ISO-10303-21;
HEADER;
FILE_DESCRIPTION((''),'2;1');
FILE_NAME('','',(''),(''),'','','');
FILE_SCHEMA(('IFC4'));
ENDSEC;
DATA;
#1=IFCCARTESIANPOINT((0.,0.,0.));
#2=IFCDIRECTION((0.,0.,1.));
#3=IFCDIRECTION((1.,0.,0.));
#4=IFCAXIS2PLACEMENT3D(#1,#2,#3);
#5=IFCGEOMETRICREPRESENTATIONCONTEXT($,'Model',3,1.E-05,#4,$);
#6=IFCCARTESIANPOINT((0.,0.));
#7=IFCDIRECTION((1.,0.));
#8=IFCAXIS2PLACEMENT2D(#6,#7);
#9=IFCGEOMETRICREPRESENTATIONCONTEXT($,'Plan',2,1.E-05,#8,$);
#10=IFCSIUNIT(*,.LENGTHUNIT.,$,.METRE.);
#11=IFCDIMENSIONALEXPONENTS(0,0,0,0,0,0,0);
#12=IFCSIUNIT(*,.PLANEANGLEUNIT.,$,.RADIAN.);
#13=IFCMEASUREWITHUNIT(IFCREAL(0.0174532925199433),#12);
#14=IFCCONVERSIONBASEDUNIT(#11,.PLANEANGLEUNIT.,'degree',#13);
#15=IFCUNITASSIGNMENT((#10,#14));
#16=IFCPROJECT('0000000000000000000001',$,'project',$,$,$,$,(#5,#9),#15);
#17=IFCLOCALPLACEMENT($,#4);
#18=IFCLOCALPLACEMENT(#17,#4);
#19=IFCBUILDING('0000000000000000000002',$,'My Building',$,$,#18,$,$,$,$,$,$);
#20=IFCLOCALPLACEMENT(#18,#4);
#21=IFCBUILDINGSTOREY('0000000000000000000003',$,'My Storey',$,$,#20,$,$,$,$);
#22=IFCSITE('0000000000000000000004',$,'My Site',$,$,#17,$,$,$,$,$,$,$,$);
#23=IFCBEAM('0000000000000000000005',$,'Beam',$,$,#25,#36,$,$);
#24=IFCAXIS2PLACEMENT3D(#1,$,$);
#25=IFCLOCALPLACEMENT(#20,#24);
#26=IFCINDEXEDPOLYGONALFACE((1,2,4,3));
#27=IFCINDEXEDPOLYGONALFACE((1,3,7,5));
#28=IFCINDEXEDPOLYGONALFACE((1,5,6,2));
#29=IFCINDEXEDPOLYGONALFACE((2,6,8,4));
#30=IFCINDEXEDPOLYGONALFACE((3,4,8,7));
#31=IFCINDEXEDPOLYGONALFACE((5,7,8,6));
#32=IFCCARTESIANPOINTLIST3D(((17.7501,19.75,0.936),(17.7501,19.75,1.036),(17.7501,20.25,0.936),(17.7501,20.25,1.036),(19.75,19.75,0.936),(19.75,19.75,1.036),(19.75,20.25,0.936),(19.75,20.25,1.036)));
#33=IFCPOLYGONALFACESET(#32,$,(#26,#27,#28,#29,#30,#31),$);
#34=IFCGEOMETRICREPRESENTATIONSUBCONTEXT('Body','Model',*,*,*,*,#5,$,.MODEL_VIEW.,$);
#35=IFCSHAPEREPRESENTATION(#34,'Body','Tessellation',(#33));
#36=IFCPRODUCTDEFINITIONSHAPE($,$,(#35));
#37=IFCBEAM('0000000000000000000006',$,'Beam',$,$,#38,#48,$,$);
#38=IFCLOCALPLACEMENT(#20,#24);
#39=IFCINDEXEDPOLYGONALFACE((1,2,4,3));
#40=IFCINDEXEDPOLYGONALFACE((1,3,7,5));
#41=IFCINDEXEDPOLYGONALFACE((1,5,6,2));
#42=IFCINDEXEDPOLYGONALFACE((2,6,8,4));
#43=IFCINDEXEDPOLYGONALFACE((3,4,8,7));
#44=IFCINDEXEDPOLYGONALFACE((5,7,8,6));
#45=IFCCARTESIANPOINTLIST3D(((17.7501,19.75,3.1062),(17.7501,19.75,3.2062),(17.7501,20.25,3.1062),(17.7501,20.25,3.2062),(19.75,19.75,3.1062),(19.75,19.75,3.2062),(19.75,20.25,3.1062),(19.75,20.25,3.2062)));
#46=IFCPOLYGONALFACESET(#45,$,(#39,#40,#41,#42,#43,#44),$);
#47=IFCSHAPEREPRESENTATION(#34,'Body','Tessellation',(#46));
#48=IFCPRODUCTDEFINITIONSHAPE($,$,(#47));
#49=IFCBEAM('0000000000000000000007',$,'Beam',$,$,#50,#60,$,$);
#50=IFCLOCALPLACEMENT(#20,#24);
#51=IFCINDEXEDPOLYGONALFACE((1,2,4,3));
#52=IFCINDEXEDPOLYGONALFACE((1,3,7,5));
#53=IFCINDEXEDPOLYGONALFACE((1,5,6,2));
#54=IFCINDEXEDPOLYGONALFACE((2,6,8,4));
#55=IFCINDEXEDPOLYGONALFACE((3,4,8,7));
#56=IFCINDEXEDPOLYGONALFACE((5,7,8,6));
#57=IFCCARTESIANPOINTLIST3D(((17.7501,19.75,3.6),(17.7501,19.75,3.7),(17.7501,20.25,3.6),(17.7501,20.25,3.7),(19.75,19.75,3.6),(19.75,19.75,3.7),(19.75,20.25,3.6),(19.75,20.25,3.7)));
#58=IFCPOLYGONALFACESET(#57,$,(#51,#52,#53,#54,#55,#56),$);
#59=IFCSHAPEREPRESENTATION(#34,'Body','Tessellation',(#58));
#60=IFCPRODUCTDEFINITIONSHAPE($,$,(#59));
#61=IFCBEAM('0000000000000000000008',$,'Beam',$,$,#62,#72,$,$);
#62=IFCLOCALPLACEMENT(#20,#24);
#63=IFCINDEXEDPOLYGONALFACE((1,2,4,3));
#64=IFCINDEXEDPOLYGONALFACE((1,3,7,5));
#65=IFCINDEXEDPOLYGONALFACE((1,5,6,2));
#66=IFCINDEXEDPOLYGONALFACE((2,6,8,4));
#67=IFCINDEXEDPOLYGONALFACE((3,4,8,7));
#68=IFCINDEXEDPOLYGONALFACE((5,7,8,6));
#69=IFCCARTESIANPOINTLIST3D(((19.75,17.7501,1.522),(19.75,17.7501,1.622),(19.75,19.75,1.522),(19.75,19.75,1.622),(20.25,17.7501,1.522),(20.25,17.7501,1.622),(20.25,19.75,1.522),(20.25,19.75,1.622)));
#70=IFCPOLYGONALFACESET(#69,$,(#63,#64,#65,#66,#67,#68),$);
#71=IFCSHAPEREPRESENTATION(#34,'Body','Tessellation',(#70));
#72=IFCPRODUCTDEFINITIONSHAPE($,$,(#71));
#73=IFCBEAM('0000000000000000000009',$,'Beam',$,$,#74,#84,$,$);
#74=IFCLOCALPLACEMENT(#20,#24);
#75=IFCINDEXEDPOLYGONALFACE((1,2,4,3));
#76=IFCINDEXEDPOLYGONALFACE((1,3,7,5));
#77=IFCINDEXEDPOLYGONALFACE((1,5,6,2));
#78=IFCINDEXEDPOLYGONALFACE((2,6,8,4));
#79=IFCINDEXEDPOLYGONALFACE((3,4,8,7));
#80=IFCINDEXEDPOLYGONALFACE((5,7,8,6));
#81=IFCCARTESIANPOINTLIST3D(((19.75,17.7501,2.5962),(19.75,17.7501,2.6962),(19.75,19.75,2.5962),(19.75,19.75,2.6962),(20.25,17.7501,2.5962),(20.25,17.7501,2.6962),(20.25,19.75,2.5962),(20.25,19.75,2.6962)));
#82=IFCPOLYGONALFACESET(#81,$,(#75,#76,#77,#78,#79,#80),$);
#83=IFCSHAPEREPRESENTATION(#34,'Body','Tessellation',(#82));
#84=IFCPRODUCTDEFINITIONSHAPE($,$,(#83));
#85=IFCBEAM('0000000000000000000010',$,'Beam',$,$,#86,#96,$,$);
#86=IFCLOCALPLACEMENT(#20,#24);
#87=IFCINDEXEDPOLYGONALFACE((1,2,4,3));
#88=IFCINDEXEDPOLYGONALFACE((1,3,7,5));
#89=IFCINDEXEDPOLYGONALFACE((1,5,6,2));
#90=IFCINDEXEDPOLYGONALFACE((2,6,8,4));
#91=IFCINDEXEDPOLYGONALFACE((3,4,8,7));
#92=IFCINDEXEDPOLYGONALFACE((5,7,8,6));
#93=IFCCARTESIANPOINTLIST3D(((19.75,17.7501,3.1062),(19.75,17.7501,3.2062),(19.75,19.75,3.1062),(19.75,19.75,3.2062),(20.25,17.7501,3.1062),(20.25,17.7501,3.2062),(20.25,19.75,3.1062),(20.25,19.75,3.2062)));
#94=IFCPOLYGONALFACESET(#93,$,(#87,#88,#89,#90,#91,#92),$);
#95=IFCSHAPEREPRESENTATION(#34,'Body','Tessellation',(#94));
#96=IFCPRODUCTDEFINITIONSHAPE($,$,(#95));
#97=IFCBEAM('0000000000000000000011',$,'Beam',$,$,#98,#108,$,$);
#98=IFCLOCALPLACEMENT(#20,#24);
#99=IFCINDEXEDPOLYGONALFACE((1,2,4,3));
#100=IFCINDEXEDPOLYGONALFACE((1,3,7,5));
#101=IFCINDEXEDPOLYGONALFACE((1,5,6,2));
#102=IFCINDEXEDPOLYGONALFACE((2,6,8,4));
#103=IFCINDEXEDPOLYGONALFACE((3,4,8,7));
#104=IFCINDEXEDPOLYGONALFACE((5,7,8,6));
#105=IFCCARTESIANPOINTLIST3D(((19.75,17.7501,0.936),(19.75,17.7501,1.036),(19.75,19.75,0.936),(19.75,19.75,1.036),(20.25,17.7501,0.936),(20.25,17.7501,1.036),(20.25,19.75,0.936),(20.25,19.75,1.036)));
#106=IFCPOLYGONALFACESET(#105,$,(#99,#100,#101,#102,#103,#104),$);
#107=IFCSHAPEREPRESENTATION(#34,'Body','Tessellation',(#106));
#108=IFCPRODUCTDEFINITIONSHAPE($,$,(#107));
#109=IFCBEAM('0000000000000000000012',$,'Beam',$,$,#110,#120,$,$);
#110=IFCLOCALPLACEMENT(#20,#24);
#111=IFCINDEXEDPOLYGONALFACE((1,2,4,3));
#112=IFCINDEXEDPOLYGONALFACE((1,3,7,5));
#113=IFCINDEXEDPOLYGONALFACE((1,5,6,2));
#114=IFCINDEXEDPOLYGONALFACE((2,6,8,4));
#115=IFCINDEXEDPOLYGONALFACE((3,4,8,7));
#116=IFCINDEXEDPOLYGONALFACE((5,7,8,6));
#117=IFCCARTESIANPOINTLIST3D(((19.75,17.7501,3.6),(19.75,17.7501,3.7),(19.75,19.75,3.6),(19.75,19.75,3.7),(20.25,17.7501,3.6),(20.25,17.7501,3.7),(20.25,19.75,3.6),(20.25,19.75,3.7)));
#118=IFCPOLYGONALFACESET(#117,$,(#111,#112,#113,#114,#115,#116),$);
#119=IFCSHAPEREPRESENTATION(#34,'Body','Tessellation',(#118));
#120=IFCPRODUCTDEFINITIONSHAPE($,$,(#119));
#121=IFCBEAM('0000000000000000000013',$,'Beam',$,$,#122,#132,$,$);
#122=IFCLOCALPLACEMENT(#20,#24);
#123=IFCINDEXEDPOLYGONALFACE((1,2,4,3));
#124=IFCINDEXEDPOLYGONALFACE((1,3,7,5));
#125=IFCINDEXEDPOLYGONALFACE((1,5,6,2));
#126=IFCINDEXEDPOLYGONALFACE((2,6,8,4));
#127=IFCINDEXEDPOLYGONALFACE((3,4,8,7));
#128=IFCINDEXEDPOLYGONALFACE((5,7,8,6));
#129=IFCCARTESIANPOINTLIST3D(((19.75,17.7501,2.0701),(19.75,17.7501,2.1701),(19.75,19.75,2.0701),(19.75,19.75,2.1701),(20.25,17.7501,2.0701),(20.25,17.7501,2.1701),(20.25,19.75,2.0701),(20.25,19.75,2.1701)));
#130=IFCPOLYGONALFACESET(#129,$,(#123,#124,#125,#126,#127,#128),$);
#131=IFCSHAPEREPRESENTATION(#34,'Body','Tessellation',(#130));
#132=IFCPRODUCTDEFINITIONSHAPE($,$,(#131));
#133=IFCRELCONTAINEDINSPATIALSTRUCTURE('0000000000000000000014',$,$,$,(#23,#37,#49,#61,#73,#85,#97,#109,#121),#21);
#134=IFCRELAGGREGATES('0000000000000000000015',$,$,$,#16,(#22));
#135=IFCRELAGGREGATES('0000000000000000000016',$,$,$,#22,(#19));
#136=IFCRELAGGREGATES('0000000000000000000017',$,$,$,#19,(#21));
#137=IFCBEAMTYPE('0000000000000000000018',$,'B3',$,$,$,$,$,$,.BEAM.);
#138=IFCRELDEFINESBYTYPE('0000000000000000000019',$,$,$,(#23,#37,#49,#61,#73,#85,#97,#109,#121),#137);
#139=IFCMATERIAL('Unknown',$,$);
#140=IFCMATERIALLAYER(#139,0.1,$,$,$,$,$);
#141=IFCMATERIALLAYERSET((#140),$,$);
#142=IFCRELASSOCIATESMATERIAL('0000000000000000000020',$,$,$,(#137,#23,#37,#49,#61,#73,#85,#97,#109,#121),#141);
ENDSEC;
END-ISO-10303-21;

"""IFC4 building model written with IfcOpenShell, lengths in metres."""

from ifc_helpers import new_model, entity, si_unit, converted_unit, frame, origin_with_axes, origin_2d_with_axis, place, context, subcontext, project, spatial, indexed_curve, outline, extrude, material, layer, layer_set, layer_usage, type_object, element, save


model = new_model("IFC4")

# Units and contexts
model_context = context("Model", 3, precision=1e-05, world=origin_with_axes())
plan_context = context("Plan", 2, precision=1e-05, world=origin_2d_with_axis())
body_context = subcontext(model_context, "Body", "Model", "MODEL_VIEW")
ifc_project = project(units=[si_unit("LENGTHUNIT", "METRE"), converted_unit("PLANEANGLEUNIT", "degree", entity("IfcReal", 0.0174532925199433), si_unit("PLANEANGLEUNIT", "RADIAN"), dimensions=[0, 0, 0, 0, 0, 0, 0])], contexts=[model_context, plan_context])

# Site, building, storey
site_placement = place(None, origin_with_axes())
site = spatial("IfcSite", under=ifc_project, at=site_placement, Name="My Site")
building_placement = place(site_placement, origin_with_axes())
building = spatial("IfcBuilding", under=site, at=building_placement, Name="My Building")
storey_placement = place(building_placement, origin_with_axes())
storey = spatial("IfcBuildingStorey", under=building, at=storey_placement, Name="My Storey")

# Shared definitions
ifc_material = material(Name="Unknown")

# Beams
ifc_layer_1 = layer(ifc_material, 0.1)
ifc_layer_set_1 = layer_set([ifc_layer_1])
beam_type_1 = type_object("IfcBeamType", Name="B3", PredefinedType="BEAM", material=ifc_layer_set_1)
ifc_layer_usage_1 = layer_usage(ifc_layer_set_1, "AXIS3", "POSITIVE", -0.1)
beam_1_placement = place(storey_placement, frame((17.7501, 19.75, 1.036), z_axis=(0.0, 0.0, 1.0), x_axis=(1.0, 0.0, 0.0)))
element("IfcBeam", 1, at=beam_1_placement, inside=storey, type_object=beam_type_1, material=ifc_layer_usage_1, Name="Beam", context=body_context, shape_type="SweptSolid", body=[
    extrude(outline(indexed_curve([(0.0, 0.0), (0.0, 0.5), (1.9999, 0.5), (1.9999, 0.0), (0.0, 0.0)])), frame((0.0, 0.0, -0.1), z_axis=(0.0, 0.0, 1.0), x_axis=(1.0, 0.0, 0.0)), (0.0, 0.0, 1.0), 0.1),
])
ifc_layer_usage_2 = layer_usage(ifc_layer_set_1, "AXIS3", "POSITIVE", -0.1)
beam_2_placement = place(storey_placement, frame((17.7501, 19.75, 3.2062), z_axis=(0.0, 0.0, 1.0), x_axis=(1.0, 0.0, 0.0)))
element("IfcBeam", 2, at=beam_2_placement, inside=storey, type_object=beam_type_1, material=ifc_layer_usage_2, Name="Beam", context=body_context, shape_type="SweptSolid", body=[
    extrude(outline(indexed_curve([(0.0, 0.0), (0.0, 0.5), (1.9999, 0.5), (1.9999, 0.0), (0.0, 0.0)])), frame((0.0, 0.0, -0.1), z_axis=(0.0, 0.0, 1.0), x_axis=(1.0, 0.0, 0.0)), (0.0, 0.0, 1.0), 0.1),
])
ifc_layer_usage_3 = layer_usage(ifc_layer_set_1, "AXIS3", "POSITIVE", -0.1)
beam_3_placement = place(storey_placement, frame((17.7501, 19.75, 3.7), z_axis=(0.0, 0.0, 1.0), x_axis=(1.0, 0.0, 0.0)))
element("IfcBeam", 3, at=beam_3_placement, inside=storey, type_object=beam_type_1, material=ifc_layer_usage_3, Name="Beam", context=body_context, shape_type="SweptSolid", body=[
    extrude(outline(indexed_curve([(0.0, 0.0), (0.0, 0.5), (1.9999, 0.5), (1.9999, 0.0), (0.0, 0.0)])), frame((0.0, 0.0, -0.1), z_axis=(0.0, 0.0, 1.0), x_axis=(1.0, 0.0, 0.0)), (0.0, 0.0, 1.0), 0.1),
])
ifc_layer_usage_4 = layer_usage(ifc_layer_set_1, "AXIS3", "POSITIVE", -0.1)
beam_4_placement = place(storey_placement, frame((20.25, 17.7501, 1.622), z_axis=(0.0, 0.0, 1.0), x_axis=(0.0, 1.0, 0.0)))
element("IfcBeam", 4, at=beam_4_placement, inside=storey, type_object=beam_type_1, material=ifc_layer_usage_4, Name="Beam", context=body_context, shape_type="SweptSolid", body=[
    extrude(outline(indexed_curve([(0.0, 0.0), (0.0, 0.5), (1.9999, 0.5), (1.9999, 0.0), (0.0, 0.0)])), frame((0.0, 0.0, -0.1), z_axis=(0.0, 0.0, 1.0), x_axis=(1.0, 0.0, 0.0)), (0.0, 0.0, 1.0), 0.1),
])
ifc_layer_usage_5 = layer_usage(ifc_layer_set_1, "AXIS3", "POSITIVE", -0.1)
beam_5_placement = place(storey_placement, frame((20.25, 17.7501, 2.6962), z_axis=(0.0, 0.0, 1.0), x_axis=(0.0, 1.0, 0.0)))
element("IfcBeam", 5, at=beam_5_placement, inside=storey, type_object=beam_type_1, material=ifc_layer_usage_5, Name="Beam", context=body_context, shape_type="SweptSolid", body=[
    extrude(outline(indexed_curve([(0.0, 0.0), (0.0, 0.5), (1.9999, 0.5), (1.9999, 0.0), (0.0, 0.0)])), frame((0.0, 0.0, -0.1), z_axis=(0.0, 0.0, 1.0), x_axis=(1.0, 0.0, 0.0)), (0.0, 0.0, 1.0), 0.1),
])
ifc_layer_usage_6 = layer_usage(ifc_layer_set_1, "AXIS3", "POSITIVE", -0.1)
beam_6_placement = place(storey_placement, frame((20.25, 17.7501, 3.2062), z_axis=(0.0, 0.0, 1.0), x_axis=(0.0, 1.0, 0.0)))
element("IfcBeam", 6, at=beam_6_placement, inside=storey, type_object=beam_type_1, material=ifc_layer_usage_6, Name="Beam", context=body_context, shape_type="SweptSolid", body=[
    extrude(outline(indexed_curve([(0.0, 0.0), (0.0, 0.5), (1.9999, 0.5), (1.9999, 0.0), (0.0, 0.0)])), frame((0.0, 0.0, -0.1), z_axis=(0.0, 0.0, 1.0), x_axis=(1.0, 0.0, 0.0)), (0.0, 0.0, 1.0), 0.1),
])
ifc_layer_usage_7 = layer_usage(ifc_layer_set_1, "AXIS3", "POSITIVE", -0.1)
beam_7_placement = place(storey_placement, frame((20.25, 17.7501, 1.036), z_axis=(0.0, 0.0, 1.0), x_axis=(0.0, 1.0, 0.0)))
element("IfcBeam", 7, at=beam_7_placement, inside=storey, type_object=beam_type_1, material=ifc_layer_usage_7, Name="Beam", context=body_context, shape_type="SweptSolid", body=[
    extrude(outline(indexed_curve([(0.0, 0.0), (0.0, 0.5), (1.9999, 0.5), (1.9999, 0.0), (0.0, 0.0)])), frame((0.0, 0.0, -0.1), z_axis=(0.0, 0.0, 1.0), x_axis=(1.0, 0.0, 0.0)), (0.0, 0.0, 1.0), 0.1),
])
ifc_layer_usage_8 = layer_usage(ifc_layer_set_1, "AXIS3", "POSITIVE", -0.1)
beam_8_placement = place(storey_placement, frame((20.25, 17.7501, 3.7), z_axis=(0.0, 0.0, 1.0), x_axis=(0.0, 1.0, 0.0)))
element("IfcBeam", 8, at=beam_8_placement, inside=storey, type_object=beam_type_1, material=ifc_layer_usage_8, Name="Beam", context=body_context, shape_type="SweptSolid", body=[
    extrude(outline(indexed_curve([(0.0, 0.0), (0.0, 0.5), (1.9999, 0.5), (1.9999, 0.0), (0.0, 0.0)])), frame((0.0, 0.0, -0.1), z_axis=(0.0, 0.0, 1.0), x_axis=(1.0, 0.0, 0.0)), (0.0, 0.0, 1.0), 0.1),
])
ifc_layer_usage_9 = layer_usage(ifc_layer_set_1, "AXIS3", "POSITIVE", -0.1)
beam_9_placement = place(storey_placement, frame((20.25, 17.7501, 2.1701), z_axis=(0.0, 0.0, 1.0), x_axis=(0.0, 1.0, 0.0)))
element("IfcBeam", 9, at=beam_9_placement, inside=storey, type_object=beam_type_1, material=ifc_layer_usage_9, Name="Beam", context=body_context, shape_type="SweptSolid", body=[
    extrude(outline(indexed_curve([(0.0, 0.0), (0.0, 0.5), (1.9999, 0.5), (1.9999, 0.0), (0.0, 0.0)])), frame((0.0, 0.0, -0.1), z_axis=(0.0, 0.0, 1.0), x_axis=(1.0, 0.0, 0.0)), (0.0, 0.0, 1.0), 0.1),
])

save(model, "model.ifc")
